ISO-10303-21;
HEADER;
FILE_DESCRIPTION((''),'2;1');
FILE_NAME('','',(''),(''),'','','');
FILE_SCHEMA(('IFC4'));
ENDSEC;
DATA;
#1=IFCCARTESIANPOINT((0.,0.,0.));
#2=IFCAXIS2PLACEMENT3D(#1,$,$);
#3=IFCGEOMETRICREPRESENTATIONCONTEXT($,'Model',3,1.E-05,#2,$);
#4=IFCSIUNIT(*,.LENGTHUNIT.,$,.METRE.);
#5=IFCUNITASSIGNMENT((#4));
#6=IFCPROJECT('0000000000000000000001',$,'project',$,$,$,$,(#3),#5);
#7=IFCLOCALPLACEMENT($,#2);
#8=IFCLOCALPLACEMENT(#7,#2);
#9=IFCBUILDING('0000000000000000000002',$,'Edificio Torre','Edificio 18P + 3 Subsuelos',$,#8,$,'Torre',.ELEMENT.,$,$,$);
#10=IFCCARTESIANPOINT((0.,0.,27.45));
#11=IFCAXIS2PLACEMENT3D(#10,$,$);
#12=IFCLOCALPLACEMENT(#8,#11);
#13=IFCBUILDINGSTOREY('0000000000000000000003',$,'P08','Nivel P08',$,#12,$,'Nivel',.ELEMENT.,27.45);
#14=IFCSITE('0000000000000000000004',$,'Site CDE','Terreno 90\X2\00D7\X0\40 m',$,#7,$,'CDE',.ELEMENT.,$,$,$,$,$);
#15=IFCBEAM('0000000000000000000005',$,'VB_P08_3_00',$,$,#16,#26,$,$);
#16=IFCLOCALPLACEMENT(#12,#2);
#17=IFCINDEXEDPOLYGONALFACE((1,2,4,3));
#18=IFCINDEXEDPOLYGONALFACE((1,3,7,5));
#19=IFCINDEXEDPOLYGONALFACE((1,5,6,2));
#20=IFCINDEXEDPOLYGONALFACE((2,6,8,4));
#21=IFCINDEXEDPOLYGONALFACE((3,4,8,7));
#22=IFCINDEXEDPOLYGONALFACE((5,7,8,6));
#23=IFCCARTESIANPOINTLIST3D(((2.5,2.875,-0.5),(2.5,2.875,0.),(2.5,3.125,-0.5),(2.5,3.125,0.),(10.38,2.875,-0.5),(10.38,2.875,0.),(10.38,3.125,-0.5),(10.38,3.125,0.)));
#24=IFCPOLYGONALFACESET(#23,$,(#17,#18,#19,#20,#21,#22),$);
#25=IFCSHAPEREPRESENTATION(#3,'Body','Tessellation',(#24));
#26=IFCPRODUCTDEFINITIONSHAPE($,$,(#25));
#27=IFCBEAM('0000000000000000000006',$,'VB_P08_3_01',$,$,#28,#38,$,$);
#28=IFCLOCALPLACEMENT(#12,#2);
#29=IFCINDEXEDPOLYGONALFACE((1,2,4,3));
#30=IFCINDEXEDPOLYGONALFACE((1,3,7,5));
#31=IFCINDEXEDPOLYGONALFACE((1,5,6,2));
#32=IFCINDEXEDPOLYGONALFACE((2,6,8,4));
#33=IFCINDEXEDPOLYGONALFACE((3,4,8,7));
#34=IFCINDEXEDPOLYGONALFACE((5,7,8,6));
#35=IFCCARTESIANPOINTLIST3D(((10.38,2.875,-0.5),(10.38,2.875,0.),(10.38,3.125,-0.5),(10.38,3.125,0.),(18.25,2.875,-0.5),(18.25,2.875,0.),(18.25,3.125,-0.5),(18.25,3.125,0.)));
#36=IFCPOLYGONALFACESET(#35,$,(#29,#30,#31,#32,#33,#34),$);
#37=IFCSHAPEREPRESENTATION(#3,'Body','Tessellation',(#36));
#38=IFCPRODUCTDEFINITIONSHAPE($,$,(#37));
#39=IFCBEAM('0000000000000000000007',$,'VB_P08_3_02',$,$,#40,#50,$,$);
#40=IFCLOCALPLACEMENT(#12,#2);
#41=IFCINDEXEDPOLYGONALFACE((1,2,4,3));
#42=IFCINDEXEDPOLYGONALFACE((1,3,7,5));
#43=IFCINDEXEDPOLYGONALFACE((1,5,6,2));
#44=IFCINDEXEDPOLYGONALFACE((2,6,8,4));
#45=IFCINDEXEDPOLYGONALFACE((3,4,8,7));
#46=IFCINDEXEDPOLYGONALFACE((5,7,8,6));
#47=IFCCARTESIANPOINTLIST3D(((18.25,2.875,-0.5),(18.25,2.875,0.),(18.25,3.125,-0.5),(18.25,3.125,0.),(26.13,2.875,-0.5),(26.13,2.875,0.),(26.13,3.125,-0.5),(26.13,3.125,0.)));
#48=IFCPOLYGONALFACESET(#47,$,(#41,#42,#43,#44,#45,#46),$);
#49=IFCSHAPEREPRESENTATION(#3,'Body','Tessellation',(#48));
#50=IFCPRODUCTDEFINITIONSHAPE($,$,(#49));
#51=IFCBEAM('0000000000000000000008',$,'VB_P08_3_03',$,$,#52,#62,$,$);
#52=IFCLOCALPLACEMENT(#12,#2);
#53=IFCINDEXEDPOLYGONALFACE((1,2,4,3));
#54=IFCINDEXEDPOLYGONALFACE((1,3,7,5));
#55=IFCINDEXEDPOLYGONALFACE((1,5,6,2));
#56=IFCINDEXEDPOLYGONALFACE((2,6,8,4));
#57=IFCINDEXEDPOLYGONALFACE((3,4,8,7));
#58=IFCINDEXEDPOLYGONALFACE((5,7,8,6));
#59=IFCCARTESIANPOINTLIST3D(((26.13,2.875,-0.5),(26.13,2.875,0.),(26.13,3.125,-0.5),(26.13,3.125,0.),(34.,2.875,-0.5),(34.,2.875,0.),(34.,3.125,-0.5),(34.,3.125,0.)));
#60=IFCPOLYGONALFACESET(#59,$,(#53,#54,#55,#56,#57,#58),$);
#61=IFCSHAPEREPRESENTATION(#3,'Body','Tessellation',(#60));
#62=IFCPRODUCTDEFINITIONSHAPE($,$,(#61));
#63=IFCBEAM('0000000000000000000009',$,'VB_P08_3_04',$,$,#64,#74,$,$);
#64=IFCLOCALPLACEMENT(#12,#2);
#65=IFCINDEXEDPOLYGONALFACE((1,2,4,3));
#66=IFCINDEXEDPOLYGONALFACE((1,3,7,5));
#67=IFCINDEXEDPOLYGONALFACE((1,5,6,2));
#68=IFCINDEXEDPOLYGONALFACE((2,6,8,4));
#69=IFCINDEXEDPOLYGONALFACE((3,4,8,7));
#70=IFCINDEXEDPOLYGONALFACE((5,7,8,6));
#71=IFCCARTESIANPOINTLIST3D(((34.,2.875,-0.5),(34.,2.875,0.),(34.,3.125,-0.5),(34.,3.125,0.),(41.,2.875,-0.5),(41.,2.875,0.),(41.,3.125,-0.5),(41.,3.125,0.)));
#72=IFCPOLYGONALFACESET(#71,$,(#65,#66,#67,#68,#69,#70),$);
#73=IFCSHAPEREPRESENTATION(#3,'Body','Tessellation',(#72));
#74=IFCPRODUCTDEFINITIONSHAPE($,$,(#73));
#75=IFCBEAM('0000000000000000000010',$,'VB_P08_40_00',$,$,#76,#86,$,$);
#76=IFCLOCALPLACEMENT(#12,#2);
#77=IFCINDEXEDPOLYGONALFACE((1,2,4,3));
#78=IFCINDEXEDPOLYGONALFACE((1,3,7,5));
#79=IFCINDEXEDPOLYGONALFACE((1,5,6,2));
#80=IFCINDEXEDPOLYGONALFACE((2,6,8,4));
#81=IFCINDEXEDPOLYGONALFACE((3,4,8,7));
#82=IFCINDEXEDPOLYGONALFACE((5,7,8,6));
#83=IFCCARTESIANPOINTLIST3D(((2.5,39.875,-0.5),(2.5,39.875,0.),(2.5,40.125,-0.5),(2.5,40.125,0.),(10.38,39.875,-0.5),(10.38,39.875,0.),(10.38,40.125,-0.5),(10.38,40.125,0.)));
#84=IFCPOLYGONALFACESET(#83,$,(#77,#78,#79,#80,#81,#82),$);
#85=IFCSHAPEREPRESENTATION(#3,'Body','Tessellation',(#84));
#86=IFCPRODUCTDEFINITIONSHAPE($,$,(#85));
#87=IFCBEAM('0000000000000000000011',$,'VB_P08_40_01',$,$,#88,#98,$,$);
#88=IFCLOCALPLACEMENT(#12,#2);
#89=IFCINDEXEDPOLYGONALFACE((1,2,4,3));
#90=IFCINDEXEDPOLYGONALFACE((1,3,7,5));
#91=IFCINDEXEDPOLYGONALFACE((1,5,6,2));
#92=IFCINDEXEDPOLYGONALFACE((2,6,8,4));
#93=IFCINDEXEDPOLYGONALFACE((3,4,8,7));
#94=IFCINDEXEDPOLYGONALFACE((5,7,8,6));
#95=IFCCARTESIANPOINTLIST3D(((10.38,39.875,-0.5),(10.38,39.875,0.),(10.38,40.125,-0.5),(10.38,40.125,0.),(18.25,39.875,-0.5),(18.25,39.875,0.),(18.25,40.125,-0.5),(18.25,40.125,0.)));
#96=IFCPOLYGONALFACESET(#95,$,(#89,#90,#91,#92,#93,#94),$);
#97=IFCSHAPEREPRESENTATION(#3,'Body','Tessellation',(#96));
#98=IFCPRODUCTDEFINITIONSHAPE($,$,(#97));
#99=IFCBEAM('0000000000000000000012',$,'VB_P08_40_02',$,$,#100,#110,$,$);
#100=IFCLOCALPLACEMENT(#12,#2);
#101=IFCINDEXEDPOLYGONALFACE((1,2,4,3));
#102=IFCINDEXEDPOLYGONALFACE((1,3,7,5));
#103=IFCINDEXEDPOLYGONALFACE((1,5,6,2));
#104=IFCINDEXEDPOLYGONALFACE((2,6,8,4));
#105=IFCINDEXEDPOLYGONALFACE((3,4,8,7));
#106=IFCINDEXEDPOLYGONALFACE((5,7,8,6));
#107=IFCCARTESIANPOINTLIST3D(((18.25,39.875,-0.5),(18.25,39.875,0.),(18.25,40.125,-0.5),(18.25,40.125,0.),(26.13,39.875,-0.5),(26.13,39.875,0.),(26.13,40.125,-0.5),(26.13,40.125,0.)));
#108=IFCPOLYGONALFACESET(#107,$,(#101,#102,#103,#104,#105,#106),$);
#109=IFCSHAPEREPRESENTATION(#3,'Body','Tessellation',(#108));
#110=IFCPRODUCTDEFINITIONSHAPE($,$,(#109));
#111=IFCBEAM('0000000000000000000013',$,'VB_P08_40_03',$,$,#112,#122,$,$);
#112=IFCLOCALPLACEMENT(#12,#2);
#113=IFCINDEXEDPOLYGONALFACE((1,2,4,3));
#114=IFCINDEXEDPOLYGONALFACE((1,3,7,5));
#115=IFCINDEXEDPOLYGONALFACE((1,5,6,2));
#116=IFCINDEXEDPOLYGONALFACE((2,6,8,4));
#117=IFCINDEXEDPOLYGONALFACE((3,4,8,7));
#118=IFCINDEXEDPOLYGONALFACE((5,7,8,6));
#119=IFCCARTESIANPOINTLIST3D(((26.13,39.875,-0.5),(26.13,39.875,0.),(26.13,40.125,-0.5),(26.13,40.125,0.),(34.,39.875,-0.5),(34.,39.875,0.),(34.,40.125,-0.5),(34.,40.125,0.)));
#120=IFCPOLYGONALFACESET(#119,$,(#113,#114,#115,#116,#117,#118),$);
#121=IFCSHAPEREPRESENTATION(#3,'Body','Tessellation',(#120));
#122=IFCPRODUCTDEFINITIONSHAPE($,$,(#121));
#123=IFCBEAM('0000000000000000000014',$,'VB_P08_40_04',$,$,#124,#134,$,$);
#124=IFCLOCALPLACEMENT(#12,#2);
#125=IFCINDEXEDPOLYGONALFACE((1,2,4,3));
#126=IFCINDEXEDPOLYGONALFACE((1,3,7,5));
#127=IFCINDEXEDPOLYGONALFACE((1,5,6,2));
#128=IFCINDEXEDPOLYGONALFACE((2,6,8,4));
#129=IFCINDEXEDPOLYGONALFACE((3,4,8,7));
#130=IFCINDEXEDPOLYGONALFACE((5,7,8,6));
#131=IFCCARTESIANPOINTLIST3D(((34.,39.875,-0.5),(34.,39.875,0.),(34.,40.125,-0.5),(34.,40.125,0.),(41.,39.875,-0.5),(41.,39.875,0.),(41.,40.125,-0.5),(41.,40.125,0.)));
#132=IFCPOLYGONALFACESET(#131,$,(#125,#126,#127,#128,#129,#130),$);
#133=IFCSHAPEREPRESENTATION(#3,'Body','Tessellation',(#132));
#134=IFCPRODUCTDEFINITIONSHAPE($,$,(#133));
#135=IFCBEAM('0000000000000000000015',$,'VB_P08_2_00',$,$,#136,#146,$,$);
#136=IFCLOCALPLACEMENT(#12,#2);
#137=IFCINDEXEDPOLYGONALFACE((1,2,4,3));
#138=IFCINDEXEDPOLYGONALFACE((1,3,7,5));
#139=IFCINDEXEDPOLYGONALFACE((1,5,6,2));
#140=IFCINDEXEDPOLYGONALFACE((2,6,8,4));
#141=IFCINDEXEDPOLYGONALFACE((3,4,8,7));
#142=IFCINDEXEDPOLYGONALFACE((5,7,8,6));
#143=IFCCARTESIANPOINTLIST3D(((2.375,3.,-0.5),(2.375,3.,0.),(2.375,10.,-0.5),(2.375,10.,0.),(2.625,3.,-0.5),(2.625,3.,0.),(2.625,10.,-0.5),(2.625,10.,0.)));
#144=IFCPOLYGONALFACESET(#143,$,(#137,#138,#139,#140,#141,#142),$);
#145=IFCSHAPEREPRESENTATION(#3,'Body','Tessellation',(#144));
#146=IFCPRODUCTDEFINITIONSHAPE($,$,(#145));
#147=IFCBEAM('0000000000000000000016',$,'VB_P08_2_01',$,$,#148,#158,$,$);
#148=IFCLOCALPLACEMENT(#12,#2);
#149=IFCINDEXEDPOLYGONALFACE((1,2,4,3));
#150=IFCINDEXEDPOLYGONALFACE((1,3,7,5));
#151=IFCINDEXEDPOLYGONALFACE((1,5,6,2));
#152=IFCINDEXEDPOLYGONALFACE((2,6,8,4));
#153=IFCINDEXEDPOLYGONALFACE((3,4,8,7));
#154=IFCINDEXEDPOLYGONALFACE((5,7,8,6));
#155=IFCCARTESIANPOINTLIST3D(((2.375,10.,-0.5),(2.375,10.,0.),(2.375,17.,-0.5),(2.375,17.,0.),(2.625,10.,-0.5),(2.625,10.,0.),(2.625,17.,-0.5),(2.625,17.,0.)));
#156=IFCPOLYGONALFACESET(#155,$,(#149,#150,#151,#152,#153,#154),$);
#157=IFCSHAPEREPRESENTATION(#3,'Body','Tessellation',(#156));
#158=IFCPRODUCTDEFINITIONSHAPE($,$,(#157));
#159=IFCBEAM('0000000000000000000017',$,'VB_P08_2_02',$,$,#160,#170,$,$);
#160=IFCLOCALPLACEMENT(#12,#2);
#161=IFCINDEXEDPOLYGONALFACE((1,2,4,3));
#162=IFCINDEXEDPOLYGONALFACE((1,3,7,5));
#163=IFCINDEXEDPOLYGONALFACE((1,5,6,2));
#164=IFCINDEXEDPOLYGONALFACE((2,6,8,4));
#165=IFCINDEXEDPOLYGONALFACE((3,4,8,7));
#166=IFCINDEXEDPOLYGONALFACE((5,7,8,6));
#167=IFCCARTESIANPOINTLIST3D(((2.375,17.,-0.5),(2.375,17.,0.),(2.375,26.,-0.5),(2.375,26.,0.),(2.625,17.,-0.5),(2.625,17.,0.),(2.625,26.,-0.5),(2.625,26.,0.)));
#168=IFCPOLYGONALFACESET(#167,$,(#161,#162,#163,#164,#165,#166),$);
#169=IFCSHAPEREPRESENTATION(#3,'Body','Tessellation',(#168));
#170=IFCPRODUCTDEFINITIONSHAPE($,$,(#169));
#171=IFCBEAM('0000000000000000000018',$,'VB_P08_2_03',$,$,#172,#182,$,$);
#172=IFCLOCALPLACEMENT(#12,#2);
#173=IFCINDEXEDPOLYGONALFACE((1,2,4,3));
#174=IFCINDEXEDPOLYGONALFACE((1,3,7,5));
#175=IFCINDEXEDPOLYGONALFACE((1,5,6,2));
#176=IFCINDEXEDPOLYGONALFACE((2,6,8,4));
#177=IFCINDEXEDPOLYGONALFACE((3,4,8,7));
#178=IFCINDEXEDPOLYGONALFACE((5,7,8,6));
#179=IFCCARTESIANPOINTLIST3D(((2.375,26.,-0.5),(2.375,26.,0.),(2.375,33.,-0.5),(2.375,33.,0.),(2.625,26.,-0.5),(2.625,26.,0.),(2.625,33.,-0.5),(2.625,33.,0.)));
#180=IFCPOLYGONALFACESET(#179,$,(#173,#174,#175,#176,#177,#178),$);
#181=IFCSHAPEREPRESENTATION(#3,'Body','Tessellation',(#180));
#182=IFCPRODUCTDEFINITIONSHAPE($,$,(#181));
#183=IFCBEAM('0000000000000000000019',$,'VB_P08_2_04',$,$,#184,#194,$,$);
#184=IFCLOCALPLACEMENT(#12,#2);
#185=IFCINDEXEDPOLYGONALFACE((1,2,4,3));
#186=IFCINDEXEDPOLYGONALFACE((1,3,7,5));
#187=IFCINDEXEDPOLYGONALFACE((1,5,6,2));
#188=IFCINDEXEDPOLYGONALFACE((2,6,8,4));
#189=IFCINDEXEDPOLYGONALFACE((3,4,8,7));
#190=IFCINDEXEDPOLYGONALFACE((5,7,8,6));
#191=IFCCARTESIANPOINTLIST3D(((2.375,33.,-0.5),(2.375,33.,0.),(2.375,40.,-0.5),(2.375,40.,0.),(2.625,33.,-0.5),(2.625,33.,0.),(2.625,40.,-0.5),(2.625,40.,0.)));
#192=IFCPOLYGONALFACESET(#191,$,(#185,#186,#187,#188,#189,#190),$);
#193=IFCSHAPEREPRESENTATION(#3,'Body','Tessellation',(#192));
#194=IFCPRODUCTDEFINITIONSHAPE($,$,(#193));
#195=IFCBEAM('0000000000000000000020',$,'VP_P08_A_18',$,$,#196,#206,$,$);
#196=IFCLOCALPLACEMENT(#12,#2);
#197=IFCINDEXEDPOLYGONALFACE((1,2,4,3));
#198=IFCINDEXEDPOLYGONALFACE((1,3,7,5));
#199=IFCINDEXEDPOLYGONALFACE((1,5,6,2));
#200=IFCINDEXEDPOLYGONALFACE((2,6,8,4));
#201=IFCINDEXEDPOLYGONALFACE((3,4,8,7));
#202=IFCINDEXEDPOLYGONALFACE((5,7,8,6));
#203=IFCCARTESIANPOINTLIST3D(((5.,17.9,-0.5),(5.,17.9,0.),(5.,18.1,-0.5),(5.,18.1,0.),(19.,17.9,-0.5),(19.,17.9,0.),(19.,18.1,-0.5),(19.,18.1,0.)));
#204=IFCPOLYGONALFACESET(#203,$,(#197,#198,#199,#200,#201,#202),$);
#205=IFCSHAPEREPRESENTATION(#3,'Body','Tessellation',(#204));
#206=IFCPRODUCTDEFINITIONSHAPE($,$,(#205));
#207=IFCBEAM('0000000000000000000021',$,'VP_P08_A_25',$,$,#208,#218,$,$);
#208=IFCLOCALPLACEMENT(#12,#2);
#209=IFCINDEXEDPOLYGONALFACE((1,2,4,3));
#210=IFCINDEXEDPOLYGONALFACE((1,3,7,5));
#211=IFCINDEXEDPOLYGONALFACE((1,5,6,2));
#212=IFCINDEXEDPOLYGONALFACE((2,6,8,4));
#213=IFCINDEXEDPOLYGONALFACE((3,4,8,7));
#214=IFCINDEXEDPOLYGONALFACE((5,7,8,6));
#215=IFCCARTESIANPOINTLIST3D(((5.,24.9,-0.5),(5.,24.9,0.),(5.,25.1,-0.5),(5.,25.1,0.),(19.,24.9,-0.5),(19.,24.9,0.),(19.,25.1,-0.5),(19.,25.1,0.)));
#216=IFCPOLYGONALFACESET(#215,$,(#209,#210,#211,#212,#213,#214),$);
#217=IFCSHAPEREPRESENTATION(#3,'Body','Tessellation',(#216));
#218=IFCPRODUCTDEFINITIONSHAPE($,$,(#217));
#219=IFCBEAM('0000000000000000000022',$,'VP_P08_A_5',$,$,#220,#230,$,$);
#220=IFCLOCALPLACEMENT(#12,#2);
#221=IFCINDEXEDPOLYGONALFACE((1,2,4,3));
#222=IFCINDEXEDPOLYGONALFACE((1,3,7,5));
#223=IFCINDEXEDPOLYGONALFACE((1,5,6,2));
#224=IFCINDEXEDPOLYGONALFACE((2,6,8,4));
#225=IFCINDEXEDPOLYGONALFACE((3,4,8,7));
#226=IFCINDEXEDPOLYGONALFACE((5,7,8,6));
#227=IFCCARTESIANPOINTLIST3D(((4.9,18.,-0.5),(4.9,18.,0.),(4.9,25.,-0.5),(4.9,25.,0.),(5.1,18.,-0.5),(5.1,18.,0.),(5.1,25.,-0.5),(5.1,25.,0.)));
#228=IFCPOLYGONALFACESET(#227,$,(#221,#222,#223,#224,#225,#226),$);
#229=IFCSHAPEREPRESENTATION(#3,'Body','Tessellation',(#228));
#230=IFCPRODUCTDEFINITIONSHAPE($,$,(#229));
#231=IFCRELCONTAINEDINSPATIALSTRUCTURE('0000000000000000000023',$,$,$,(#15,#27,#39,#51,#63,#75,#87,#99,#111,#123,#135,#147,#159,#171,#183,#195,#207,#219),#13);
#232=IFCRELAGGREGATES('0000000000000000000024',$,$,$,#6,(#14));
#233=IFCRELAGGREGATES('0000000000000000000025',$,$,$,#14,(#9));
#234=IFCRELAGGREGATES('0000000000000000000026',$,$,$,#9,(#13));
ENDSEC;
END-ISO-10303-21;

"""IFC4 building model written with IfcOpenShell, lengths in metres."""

from ifc_helpers import new_model, si_unit, frame, origin, origin_2d, place, context, project, spatial, rectangle, extrude, element, save


model = new_model("IFC4")

# Units and contexts
model_context = context("Model", 3, precision=1e-05, world=origin())
ifc_project = project(units=[si_unit("LENGTHUNIT", "METRE")], contexts=[model_context])

# Site, building, storey
site_placement = place(None, origin())
site = spatial("IfcSite", under=ifc_project, at=site_placement, Name="Site CDE", Description="Terreno 90×40 m", LongName="CDE", CompositionType="ELEMENT")
building_placement = place(site_placement, origin())
building = spatial("IfcBuilding", under=site, at=building_placement, Name="Edificio Torre", Description="Edificio 18P + 3 Subsuelos", LongName="Torre", CompositionType="ELEMENT")
storey_placement = place(building_placement, frame((0.0, 0.0, 27.45)))
storey = spatial("IfcBuildingStorey", under=building, at=storey_placement, Name="P08", Description="Nivel P08", LongName="Nivel", CompositionType="ELEMENT", Elevation=27.45)

# Beams
beam_1_placement = place(storey_placement, frame((6.44, 3.0, -0.5)))
element("IfcBeam", 1, at=beam_1_placement, inside=storey, Name="VB_P08_3_00", context=model_context, shape_type="SweptSolid", body=[
    extrude(rectangle(XDim=7.88, YDim=0.25, at=origin_2d()), origin(), (0.0, 0.0, 1.0), 0.5),
])
beam_2_placement = place(storey_placement, frame((14.315, 3.0, -0.5)))
element("IfcBeam", 2, at=beam_2_placement, inside=storey, Name="VB_P08_3_01", context=model_context, shape_type="SweptSolid", body=[
    extrude(rectangle(XDim=7.87, YDim=0.25, at=origin_2d()), origin(), (0.0, 0.0, 1.0), 0.5),
])
beam_3_placement = place(storey_placement, frame((22.19, 3.0, -0.5)))
element("IfcBeam", 3, at=beam_3_placement, inside=storey, Name="VB_P08_3_02", context=model_context, shape_type="SweptSolid", body=[
    extrude(rectangle(XDim=7.88, YDim=0.25, at=origin_2d()), origin(), (0.0, 0.0, 1.0), 0.5),
])
beam_4_placement = place(storey_placement, frame((30.065, 3.0, -0.5)))
element("IfcBeam", 4, at=beam_4_placement, inside=storey, Name="VB_P08_3_03", context=model_context, shape_type="SweptSolid", body=[
    extrude(rectangle(XDim=7.87, YDim=0.25, at=origin_2d()), origin(), (0.0, 0.0, 1.0), 0.5),
])
beam_5_placement = place(storey_placement, frame((37.5, 3.0, -0.5)))
element("IfcBeam", 5, at=beam_5_placement, inside=storey, Name="VB_P08_3_04", context=model_context, shape_type="SweptSolid", body=[
    extrude(rectangle(XDim=7.0, YDim=0.25, at=origin_2d()), origin(), (0.0, 0.0, 1.0), 0.5),
])
beam_6_placement = place(storey_placement, frame((6.44, 40.0, -0.5)))
element("IfcBeam", 6, at=beam_6_placement, inside=storey, Name="VB_P08_40_00", context=model_context, shape_type="SweptSolid", body=[
    extrude(rectangle(XDim=7.88, YDim=0.25, at=origin_2d()), origin(), (0.0, 0.0, 1.0), 0.5),
])
beam_7_placement = place(storey_placement, frame((14.315, 40.0, -0.5)))
element("IfcBeam", 7, at=beam_7_placement, inside=storey, Name="VB_P08_40_01", context=model_context, shape_type="SweptSolid", body=[
    extrude(rectangle(XDim=7.87, YDim=0.25, at=origin_2d()), origin(), (0.0, 0.0, 1.0), 0.5),
])
beam_8_placement = place(storey_placement, frame((22.19, 40.0, -0.5)))
element("IfcBeam", 8, at=beam_8_placement, inside=storey, Name="VB_P08_40_02", context=model_context, shape_type="SweptSolid", body=[
    extrude(rectangle(XDim=7.88, YDim=0.25, at=origin_2d()), origin(), (0.0, 0.0, 1.0), 0.5),
])
beam_9_placement = place(storey_placement, frame((30.065, 40.0, -0.5)))
element("IfcBeam", 9, at=beam_9_placement, inside=storey, Name="VB_P08_40_03", context=model_context, shape_type="SweptSolid", body=[
    extrude(rectangle(XDim=7.87, YDim=0.25, at=origin_2d()), origin(), (0.0, 0.0, 1.0), 0.5),
])
beam_10_placement = place(storey_placement, frame((37.5, 40.0, -0.5)))
element("IfcBeam", 10, at=beam_10_placement, inside=storey, Name="VB_P08_40_04", context=model_context, shape_type="SweptSolid", body=[
    extrude(rectangle(XDim=7.0, YDim=0.25, at=origin_2d()), origin(), (0.0, 0.0, 1.0), 0.5),
])
for number, where, name in (
    (11, (2.5, 6.5, -0.5), "VB_P08_2_00"),
    (12, (2.5, 13.5, -0.5), "VB_P08_2_01"),
):
    element("IfcBeam", number, at=place(storey_placement, frame(where)), inside=storey, Name=name, context=model_context, shape_type="SweptSolid", body=[
        extrude(rectangle(XDim=0.25, YDim=7.0, at=origin_2d()), origin(), (0.0, 0.0, 1.0), 0.5),
    ])
beam_11_placement = place(storey_placement, frame((2.5, 21.5, -0.5)))
element("IfcBeam", 13, at=beam_11_placement, inside=storey, Name="VB_P08_2_02", context=model_context, shape_type="SweptSolid", body=[
    extrude(rectangle(XDim=0.25, YDim=9.0, at=origin_2d()), origin(), (0.0, 0.0, 1.0), 0.5),
])
for number, where, name in (
    (14, (2.5, 29.5, -0.5), "VB_P08_2_03"),
    (15, (2.5, 36.5, -0.5), "VB_P08_2_04"),
):
    element("IfcBeam", number, at=place(storey_placement, frame(where)), inside=storey, Name=name, context=model_context, shape_type="SweptSolid", body=[
        extrude(rectangle(XDim=0.25, YDim=7.0, at=origin_2d()), origin(), (0.0, 0.0, 1.0), 0.5),
    ])
for number, where, name in (
    (16, (12.0, 18.0, -0.5), "VP_P08_A_18"),
    (17, (12.0, 25.0, -0.5), "VP_P08_A_25"),
):
    element("IfcBeam", number, at=place(storey_placement, frame(where)), inside=storey, Name=name, context=model_context, shape_type="SweptSolid", body=[
        extrude(rectangle(XDim=14.0, YDim=0.2, at=origin_2d()), origin(), (0.0, 0.0, 1.0), 0.5),
    ])
beam_12_placement = place(storey_placement, frame((5.0, 21.5, -0.5)))
element("IfcBeam", 18, at=beam_12_placement, inside=storey, Name="VP_P08_A_5", context=model_context, shape_type="SweptSolid", body=[
    extrude(rectangle(XDim=0.2, YDim=7.0, at=origin_2d()), origin(), (0.0, 0.0, 1.0), 0.5),
])

save(model, "model.ifc")
